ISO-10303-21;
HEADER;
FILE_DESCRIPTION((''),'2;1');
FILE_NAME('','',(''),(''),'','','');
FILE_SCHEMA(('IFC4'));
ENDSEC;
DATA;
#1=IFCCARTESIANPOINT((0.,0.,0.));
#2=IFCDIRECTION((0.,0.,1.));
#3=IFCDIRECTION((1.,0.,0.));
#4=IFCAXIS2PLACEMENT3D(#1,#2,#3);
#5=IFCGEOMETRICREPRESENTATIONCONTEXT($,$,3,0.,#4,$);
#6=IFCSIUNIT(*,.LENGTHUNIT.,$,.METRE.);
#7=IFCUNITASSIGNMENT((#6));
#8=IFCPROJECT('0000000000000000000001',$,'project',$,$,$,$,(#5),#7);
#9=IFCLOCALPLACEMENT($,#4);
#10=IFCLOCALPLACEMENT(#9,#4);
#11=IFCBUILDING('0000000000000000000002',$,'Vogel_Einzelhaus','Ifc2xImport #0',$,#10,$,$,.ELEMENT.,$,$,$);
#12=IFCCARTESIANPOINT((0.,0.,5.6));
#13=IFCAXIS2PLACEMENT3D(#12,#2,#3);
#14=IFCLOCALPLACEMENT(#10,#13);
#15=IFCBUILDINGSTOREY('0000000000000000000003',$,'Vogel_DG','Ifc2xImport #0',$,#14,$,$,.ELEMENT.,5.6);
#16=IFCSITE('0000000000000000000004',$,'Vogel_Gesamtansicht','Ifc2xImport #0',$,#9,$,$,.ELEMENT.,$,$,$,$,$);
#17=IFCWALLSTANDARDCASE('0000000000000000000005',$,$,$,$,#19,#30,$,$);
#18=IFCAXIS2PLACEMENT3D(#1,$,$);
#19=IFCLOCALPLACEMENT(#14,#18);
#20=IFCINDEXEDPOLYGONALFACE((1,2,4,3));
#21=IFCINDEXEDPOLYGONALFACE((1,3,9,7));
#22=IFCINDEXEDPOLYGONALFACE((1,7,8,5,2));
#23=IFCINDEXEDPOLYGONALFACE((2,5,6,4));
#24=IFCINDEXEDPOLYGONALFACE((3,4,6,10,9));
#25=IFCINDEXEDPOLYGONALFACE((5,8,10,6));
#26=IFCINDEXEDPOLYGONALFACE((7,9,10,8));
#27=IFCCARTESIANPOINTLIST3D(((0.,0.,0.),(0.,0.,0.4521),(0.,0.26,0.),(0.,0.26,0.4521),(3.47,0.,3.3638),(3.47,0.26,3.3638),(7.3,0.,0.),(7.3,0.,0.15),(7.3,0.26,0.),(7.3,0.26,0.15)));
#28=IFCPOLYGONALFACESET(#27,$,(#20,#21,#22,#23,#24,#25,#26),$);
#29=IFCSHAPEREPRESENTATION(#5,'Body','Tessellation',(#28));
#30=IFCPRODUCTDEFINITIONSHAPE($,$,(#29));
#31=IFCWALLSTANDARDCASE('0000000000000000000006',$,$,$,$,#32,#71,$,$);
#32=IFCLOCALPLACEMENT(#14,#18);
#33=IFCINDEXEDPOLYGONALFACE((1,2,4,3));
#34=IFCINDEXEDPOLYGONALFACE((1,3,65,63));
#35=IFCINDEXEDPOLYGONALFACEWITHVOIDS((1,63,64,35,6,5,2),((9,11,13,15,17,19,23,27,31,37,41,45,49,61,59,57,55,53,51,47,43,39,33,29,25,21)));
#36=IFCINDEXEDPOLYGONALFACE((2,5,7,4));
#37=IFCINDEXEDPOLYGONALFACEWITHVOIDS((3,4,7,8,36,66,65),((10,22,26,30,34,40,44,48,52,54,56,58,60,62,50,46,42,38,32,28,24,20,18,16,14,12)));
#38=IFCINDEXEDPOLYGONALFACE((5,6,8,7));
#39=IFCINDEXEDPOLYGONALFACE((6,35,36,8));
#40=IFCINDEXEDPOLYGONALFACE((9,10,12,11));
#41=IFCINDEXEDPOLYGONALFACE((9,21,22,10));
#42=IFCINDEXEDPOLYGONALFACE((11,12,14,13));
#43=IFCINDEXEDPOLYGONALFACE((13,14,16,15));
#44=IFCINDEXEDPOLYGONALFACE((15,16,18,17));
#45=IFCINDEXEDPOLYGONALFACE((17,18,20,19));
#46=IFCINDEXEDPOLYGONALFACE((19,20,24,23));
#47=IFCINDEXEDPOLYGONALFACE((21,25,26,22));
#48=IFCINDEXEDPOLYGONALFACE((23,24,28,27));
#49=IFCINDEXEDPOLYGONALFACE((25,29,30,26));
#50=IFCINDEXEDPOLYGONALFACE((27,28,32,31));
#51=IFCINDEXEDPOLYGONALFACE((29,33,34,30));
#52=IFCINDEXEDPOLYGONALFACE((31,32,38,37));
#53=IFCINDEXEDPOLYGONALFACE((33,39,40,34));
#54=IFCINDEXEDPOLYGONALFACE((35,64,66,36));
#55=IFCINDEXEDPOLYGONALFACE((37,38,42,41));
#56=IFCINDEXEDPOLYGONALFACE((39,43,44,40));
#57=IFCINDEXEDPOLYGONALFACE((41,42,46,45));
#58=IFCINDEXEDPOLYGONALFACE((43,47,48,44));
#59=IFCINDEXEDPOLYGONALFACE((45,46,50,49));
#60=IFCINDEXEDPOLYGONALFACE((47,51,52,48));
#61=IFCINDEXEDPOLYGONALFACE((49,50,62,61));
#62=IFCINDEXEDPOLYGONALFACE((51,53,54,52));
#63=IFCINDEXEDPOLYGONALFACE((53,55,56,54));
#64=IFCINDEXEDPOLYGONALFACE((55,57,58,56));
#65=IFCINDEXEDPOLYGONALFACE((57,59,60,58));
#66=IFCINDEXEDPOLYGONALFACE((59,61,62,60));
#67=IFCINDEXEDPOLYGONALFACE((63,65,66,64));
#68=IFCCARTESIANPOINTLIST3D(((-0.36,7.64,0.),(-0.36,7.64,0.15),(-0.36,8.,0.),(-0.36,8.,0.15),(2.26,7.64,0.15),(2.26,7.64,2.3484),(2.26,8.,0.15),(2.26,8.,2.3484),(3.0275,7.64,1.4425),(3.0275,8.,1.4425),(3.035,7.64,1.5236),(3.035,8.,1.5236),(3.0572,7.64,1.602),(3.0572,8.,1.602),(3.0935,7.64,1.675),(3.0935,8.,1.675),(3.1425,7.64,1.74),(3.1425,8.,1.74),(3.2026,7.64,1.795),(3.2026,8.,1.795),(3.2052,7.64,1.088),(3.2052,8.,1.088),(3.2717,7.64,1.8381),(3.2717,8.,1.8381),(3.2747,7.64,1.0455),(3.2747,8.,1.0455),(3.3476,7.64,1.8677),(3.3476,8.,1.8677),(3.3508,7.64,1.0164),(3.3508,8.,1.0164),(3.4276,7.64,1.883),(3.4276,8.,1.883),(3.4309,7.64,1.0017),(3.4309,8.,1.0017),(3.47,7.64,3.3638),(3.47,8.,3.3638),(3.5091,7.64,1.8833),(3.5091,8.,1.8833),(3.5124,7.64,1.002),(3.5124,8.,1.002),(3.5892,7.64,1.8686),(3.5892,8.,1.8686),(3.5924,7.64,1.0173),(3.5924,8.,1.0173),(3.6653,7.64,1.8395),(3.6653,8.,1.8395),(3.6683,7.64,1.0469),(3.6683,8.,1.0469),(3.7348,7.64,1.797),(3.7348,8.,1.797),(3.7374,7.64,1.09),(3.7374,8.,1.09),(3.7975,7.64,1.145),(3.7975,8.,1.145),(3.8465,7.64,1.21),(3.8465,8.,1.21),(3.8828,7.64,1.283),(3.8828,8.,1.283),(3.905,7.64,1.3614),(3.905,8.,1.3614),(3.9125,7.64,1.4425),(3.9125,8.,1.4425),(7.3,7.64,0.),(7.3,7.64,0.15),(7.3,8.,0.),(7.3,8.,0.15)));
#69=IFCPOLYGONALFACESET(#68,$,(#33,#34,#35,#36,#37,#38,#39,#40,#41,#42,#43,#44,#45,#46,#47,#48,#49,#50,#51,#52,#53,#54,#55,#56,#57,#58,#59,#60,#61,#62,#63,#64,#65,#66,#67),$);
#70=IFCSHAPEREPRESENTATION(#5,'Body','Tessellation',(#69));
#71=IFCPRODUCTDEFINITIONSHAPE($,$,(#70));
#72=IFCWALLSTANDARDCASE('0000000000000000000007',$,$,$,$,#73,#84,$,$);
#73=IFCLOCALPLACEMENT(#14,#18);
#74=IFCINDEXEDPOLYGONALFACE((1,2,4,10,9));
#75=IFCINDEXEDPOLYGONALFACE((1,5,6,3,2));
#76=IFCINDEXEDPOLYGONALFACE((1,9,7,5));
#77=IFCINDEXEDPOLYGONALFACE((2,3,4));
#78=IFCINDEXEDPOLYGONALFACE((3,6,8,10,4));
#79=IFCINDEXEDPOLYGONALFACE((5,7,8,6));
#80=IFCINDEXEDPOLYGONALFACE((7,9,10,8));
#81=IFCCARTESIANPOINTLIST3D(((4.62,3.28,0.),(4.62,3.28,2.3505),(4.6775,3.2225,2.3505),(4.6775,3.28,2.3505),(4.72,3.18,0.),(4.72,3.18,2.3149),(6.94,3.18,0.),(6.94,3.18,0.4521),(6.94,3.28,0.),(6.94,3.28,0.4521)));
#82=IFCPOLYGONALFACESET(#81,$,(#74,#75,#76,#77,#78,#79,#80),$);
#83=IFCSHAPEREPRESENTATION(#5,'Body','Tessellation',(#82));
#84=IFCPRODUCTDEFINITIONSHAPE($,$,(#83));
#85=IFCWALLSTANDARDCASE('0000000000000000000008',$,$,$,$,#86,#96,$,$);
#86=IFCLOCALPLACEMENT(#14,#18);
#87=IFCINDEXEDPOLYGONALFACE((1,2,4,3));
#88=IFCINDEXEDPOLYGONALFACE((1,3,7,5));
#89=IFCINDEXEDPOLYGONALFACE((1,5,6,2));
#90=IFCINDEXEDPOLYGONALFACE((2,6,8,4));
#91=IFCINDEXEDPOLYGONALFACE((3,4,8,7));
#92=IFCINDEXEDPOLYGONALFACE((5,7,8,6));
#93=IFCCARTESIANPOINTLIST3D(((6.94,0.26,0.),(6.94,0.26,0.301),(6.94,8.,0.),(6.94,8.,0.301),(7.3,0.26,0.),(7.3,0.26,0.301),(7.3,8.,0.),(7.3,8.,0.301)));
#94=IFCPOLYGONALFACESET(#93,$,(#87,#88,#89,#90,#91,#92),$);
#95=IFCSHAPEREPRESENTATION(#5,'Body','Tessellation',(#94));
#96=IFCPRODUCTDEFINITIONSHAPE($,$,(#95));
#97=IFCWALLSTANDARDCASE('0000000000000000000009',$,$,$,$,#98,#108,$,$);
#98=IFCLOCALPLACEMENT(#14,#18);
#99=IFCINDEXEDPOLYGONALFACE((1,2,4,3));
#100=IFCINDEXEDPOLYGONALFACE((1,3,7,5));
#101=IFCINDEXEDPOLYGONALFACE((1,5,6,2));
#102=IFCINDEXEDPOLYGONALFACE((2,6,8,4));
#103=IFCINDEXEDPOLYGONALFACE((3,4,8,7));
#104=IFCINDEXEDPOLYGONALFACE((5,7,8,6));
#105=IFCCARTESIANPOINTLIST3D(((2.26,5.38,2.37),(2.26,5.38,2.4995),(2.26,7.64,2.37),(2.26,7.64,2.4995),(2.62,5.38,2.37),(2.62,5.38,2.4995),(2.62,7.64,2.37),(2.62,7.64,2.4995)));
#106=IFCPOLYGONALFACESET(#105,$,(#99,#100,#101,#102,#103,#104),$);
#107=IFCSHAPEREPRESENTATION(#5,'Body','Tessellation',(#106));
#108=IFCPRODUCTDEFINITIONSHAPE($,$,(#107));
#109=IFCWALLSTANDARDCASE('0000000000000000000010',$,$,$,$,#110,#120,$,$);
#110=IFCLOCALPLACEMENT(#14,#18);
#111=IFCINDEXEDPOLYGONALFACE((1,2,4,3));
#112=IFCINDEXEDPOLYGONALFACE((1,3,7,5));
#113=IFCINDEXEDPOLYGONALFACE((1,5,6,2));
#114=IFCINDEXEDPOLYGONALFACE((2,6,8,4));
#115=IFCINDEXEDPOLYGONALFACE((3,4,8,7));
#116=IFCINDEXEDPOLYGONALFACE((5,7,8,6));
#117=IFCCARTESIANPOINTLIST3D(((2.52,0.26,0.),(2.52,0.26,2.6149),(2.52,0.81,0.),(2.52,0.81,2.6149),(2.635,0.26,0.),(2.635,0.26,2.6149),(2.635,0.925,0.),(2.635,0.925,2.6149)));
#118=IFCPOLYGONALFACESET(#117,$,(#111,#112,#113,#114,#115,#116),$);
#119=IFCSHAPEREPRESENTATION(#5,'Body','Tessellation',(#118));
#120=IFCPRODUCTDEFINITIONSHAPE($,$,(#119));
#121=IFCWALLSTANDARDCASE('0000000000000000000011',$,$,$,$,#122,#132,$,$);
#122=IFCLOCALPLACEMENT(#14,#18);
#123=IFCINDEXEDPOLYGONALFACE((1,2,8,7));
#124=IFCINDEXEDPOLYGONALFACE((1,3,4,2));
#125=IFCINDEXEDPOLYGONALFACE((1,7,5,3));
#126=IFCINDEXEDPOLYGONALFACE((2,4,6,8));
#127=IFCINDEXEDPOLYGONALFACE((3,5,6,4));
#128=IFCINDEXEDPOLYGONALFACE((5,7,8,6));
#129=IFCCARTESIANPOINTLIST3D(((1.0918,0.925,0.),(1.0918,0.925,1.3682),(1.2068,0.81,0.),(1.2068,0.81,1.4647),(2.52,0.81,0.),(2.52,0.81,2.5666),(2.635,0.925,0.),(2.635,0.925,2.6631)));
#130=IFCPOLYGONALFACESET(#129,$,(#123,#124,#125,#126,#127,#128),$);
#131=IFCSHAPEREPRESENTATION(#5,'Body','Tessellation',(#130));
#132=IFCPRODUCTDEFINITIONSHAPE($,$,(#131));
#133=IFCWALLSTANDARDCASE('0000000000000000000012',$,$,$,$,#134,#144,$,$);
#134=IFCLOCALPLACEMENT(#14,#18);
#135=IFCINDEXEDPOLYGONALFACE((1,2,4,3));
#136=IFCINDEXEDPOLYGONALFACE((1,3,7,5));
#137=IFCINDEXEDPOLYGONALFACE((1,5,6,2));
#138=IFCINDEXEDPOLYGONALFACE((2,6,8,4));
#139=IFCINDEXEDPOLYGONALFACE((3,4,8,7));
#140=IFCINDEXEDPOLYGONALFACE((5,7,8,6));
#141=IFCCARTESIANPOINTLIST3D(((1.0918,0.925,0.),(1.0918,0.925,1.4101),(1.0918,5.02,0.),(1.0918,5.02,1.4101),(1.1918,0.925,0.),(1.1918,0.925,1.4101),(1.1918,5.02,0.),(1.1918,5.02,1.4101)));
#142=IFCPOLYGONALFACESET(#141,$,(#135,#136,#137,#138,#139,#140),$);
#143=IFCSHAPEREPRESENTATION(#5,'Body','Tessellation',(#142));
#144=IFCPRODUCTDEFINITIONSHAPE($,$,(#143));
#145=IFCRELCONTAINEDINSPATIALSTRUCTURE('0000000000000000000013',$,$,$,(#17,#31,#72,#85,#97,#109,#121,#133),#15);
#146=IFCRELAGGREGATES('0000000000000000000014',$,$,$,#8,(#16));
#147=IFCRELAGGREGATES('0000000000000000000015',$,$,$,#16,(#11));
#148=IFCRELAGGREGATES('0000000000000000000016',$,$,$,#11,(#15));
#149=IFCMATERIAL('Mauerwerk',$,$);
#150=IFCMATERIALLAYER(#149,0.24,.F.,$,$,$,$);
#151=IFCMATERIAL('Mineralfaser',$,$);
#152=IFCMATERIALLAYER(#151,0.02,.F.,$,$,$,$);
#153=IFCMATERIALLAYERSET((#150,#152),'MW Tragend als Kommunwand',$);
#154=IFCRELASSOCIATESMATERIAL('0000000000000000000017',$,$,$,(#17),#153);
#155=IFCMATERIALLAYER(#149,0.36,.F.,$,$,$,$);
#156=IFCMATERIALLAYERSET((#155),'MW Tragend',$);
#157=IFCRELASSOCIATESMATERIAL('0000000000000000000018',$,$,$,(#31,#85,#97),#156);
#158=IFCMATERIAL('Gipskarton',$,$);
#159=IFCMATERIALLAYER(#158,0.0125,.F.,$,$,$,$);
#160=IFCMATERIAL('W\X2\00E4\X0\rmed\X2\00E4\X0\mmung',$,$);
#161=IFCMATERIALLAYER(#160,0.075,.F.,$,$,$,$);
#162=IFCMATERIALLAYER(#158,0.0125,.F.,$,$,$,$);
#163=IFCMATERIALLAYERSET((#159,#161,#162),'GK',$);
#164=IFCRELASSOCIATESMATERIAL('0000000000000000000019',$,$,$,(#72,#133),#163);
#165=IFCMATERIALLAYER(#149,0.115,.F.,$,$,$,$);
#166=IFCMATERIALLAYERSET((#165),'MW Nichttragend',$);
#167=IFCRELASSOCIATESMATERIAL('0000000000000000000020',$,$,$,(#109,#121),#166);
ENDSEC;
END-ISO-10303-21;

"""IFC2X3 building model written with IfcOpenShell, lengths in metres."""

from ifc_helpers import new_model, si_unit, point, frame, frame_2d, origin_with_axes, origin_2d_with_axis, place, context, project, spatial, polyline, circle_curve, parameter, trimmed, segment, composite_curve, rectangle, outline, extrude, clip, bounded_halfspace, shape, material, layer, layer_set, layer_usage, element, save


model = new_model("IFC2X3")

# Units and contexts
context_of_model = context(None, 3, precision=0.0, world=origin_with_axes())
ifc_project = project(units=[si_unit("LENGTHUNIT", "METRE")], contexts=[context_of_model])

# Site, building, storey
site_placement = place(None, origin_with_axes())
site = spatial("IfcSite", under=ifc_project, at=site_placement, Name="Vogel_Gesamtansicht", Description="Ifc2xImport #0", CompositionType="ELEMENT")
building_placement = place(site_placement, origin_with_axes())
building = spatial("IfcBuilding", under=site, at=building_placement, Name="Vogel_Einzelhaus", Description="Ifc2xImport #0", CompositionType="ELEMENT")
storey_placement = place(building_placement, frame((0.0, 0.0, 5.6), z_axis=(0.0, 0.0, 1.0), x_axis=(1.0, 0.0, 0.0)))
storey = spatial("IfcBuildingStorey", under=building, at=storey_placement, Name="Vogel_DG", Description="Ifc2xImport #0", CompositionType="ELEMENT", Elevation=5.6)

# Wall
ifc_material_1 = material(Name="Mauerwerk")
ifc_layer_1 = layer(ifc_material_1, 0.24, ventilated=False)
ifc_material_2 = material(Name="Mineralfaser")
ifc_layer_2 = layer(ifc_material_2, 0.02, ventilated=False)
ifc_layer_set_1 = layer_set([ifc_layer_1, ifc_layer_2], Name="MW Tragend als Kommunwand")
ifc_layer_usage_1 = layer_usage(ifc_layer_set_1, "AXIS2", "POSITIVE", -0.26)
wall_1_placement = place(storey_placement, frame((7.3, 0.0, 0.0), z_axis=(0.0, 0.0, 1.0), x_axis=(-1.0, 0.0, 0.0)))
element("IfcWallStandardCase", 1, at=wall_1_placement, inside=storey, material=ifc_layer_usage_1, context=context_of_model, shape_type="Clipping", body=[
    clip(clip(extrude(outline(polyline([(0.0, -0.26), (2.58, -0.26), (2.68, -0.26), (4.665, -0.26), (4.78, -0.26), (6.0932, -0.26), (6.2082, -0.26), (7.3, -0.26), (7.3, 0.0), (0.0, 0.0), (0.0, -0.26)])), origin_with_axes(), (0.0, 0.0, 1.0), 3.3638), bounded_halfspace(frame((0.0, 0.0, 0.15), z_axis=(0.642788, 0.0, -0.766044), x_axis=(0.766044, 0.0, 0.642788)), True, origin_with_axes(), polyline([(-7.3, -0.26), (3.83, -0.26), (3.83, 0.26), (-7.3, 0.26), (-7.3, -0.26)]))), bounded_halfspace(frame((3.83, 0.0, 3.3638), z_axis=(-0.642788, 0.0, -0.766044), x_axis=(0.766044, 0.0, -0.642788)), True, origin_with_axes(), polyline([(3.83, -0.26), (14.6, -0.26), (14.6, 0.26), (3.83, 0.26), (3.83, -0.26)]))),
])

# Wall, opening
ifc_layer_3 = layer(ifc_material_1, 0.36, ventilated=False)
ifc_layer_set_2 = layer_set([ifc_layer_3], Name="MW Tragend")
ifc_layer_usage_2 = layer_usage(ifc_layer_set_2, "AXIS2", "POSITIVE", -0.36)
wall_2_placement = place(storey_placement, frame((-0.36, 8.0, 0.0), z_axis=(0.0, 0.0, 1.0), x_axis=(1.0, 0.0, 0.0)))
wall_2 = element("IfcWallStandardCase", 2, at=wall_2_placement, inside=storey, material=ifc_layer_usage_2, context=context_of_model, shape_type="Clipping", body=[
    clip(clip(clip(extrude(outline(polyline([(0.0, 0.0), (0.0, -0.36), (7.66, -0.36), (7.66, 0.0), (0.0, 0.0)])), origin_with_axes(), (0.0, 0.0, 1.0), 3.3638), bounded_halfspace(frame((0.0, 0.0, 0.15), z_axis=(0.0, 0.0, -1.0), x_axis=(1.0, 0.0, 0.0)), True, origin_with_axes(), polyline([(-7.66, -0.36), (2.62, -0.36), (2.62, 0.36), (-7.66, 0.36), (-7.66, -0.36)]))), bounded_halfspace(frame((2.62, 0.0, 2.3484), z_axis=(0.642788, 0.0, -0.766044), x_axis=(0.766044, 0.0, 0.642788)), True, origin_with_axes(), polyline([(2.62, -0.36), (3.83, -0.36), (3.83, 0.36), (2.62, 0.36), (2.62, -0.36)]))), bounded_halfspace(frame((3.83, 0.0, 3.3638), z_axis=(-0.642788, 0.0, -0.766044), x_axis=(0.766044, 0.0, -0.642788)), True, origin_with_axes(), polyline([(3.83, -0.36), (15.32, -0.36), (15.32, 0.36), (3.83, 0.36), (3.83, -0.36)]))),
])
opening_1_placement = place(wall_2_placement, frame((4.2725, -0.36, 1.0), z_axis=(-1.0, 0.0, 0.0), x_axis=(0.0, 0.0, 1.0)))
element("IfcOpeningElement", 3, at=opening_1_placement, cuts=wall_2, shapes=[
    shape(context_of_model, None, "SweptSolid", [extrude(outline(composite_curve([segment(trimmed(circle_curve(frame_2d((0.4425, 0.4425), x_axis=(1.0, 0.0)), 0.4425), [parameter(0.0), point((0.885, 0.4425))], [parameter(180.0), point((0.0, 0.4425))], True, "PARAMETER"), True, "CONTINUOUS"), segment(trimmed(circle_curve(frame_2d((0.4425, 0.4425), x_axis=(-1.0, 0.0)), 0.4425), [parameter(0.0), point((0.0, 0.4425))], [parameter(180.0), point((0.885, 0.4425))], True, "PARAMETER"), True, "CONTINUOUS")], self_intersect="UNKNOWN")), frame((0.0, 0.0, 0.0), z_axis=(0.0, 1.0, 0.0), x_axis=(0.0, 0.0, 1.0)), (0.0, 0.0, 1.0), 0.36)]),
])

# Walls
ifc_material_3 = material(Name="Gipskarton")
ifc_layer_4 = layer(ifc_material_3, 0.0125, ventilated=False)
ifc_material_4 = material(Name="Wärmedämmung")
ifc_layer_5 = layer(ifc_material_4, 0.075, ventilated=False)
ifc_layer_6 = layer(ifc_material_3, 0.0125, ventilated=False)
ifc_layer_set_3 = layer_set([ifc_layer_4, ifc_layer_5, ifc_layer_6], Name="GK")
ifc_layer_usage_3 = layer_usage(ifc_layer_set_3, "AXIS2", "POSITIVE", -0.1)
wall_3_placement = place(storey_placement, frame((4.6775, 3.28, 0.0), z_axis=(0.0, 0.0, 1.0), x_axis=(1.0, 0.0, 0.0)))
element("IfcWallStandardCase", 4, at=wall_3_placement, inside=storey, material=ifc_layer_usage_3, context=context_of_model, shape_type="Clipping", body=[
    clip(extrude(outline(polyline([(2.2625, -0.1), (2.2625, 0.0), (-0.0575, 0.0), (0.0425, -0.1), (2.2625, -0.1)])), origin_with_axes(), (0.0, 0.0, 1.0), 2.3505), bounded_halfspace(frame((0.0, 0.0, 2.3505), z_axis=(-0.642788, 0.0, -0.766044), x_axis=(0.766044, 0.0, -0.642788)), True, origin_with_axes(), polyline([(-2.2625, -0.1), (2.2625, -0.1), (2.2625, 0.1), (-2.2625, 0.1), (-2.2625, -0.1)]))),
])
wall_4_placement = place(storey_placement, frame((7.3, 8.0, 0.0), z_axis=(0.0, 0.0, 1.0), x_axis=(0.0, -1.0, 0.0)))
element("IfcWallStandardCase", 5, at=wall_4_placement, inside=storey, material=ifc_layer_usage_2, context=context_of_model, shape_type="Clipping", body=[
    clip(extrude(outline(polyline([(0.0, 0.0), (0.0, -0.36), (7.74, -0.36), (7.74, 0.0), (0.0, 0.0)])), origin_with_axes(), (0.0, 0.0, 1.0), 0.301), bounded_halfspace(frame((0.0, 0.0, 0.301), z_axis=(0.0, 0.0, -1.0), x_axis=(1.0, 0.0, 0.0)), True, origin_with_axes(), polyline([(-7.74, -0.36), (7.74, -0.36), (7.74, 0.36), (-7.74, 0.36), (-7.74, -0.36)]))),
])

# Wall, opening
ifc_layer_usage_4 = layer_usage(ifc_layer_set_2, "AXIS2", "POSITIVE", 0.0)
wall_5_placement = place(storey_placement, frame((2.26, 7.64, 0.0), z_axis=(0.0, 0.0, 1.0), x_axis=(0.0, -1.0, 0.0)))
wall_5 = element("IfcWallStandardCase", 6, at=wall_5_placement, inside=storey, material=ifc_layer_usage_4, context=context_of_model, shape_type="Clipping", body=[
    clip(extrude(outline(polyline([(0.0, 0.36), (0.0, 0.0), (2.26, 0.0), (2.26, 0.36), (0.0, 0.36)])), origin_with_axes(), (0.0, 0.0, 1.0), 2.4995), bounded_halfspace(frame((0.0, 0.0, 2.4995), z_axis=(0.0, 0.0, -1.0), x_axis=(1.0, 0.0, 0.0)), True, origin_with_axes(), polyline([(-2.26, -0.36), (2.26, -0.36), (2.26, 0.36), (-2.26, 0.36), (-2.26, -0.36)]))),
])
opening_2_placement = place(wall_5_placement, frame((0.0, 0.36, 0.0), z_axis=(1.0, 0.0, 0.0), x_axis=(0.0, 0.0, 1.0)))
element("IfcOpeningElement", 7, at=opening_2_placement, cuts=wall_5, shapes=[
    shape(context_of_model, None, "SweptSolid", [extrude(rectangle(XDim=2.37, YDim=2.26, at=origin_2d_with_axis()), frame((1.185, 0.0, 1.13), z_axis=(0.0, 1.0, 0.0), x_axis=(1.0, 0.0, 0.0)), (0.0, 0.0, 1.0), 0.36)]),
])

# Walls
ifc_layer_7 = layer(ifc_material_1, 0.115, ventilated=False)
ifc_layer_set_4 = layer_set([ifc_layer_7], Name="MW Nichttragend")
ifc_layer_usage_5 = layer_usage(ifc_layer_set_4, "AXIS2", "POSITIVE", -0.115)
wall_6_placement = place(storey_placement, frame((2.52, 0.26, 0.0), z_axis=(0.0, 0.0, 1.0), x_axis=(0.0, 1.0, 0.0)))
element("IfcWallStandardCase", 8, at=wall_6_placement, inside=storey, material=ifc_layer_usage_5, context=context_of_model, shape_type="Clipping", body=[
    clip(extrude(outline(polyline([(0.665, -0.115), (0.55, 0.0), (0.0, 0.0), (0.0, -0.115), (0.665, -0.115)])), origin_with_axes(), (0.0, 0.0, 1.0), 2.6149), bounded_halfspace(frame((0.0, 0.0, 2.6149), z_axis=(0.0, 0.0, -1.0), x_axis=(1.0, 0.0, 0.0)), True, origin_with_axes(), polyline([(-0.55, -0.115), (0.55, -0.115), (0.55, 0.115), (-0.55, 0.115), (-0.55, -0.115)]))),
])
wall_7_placement = place(storey_placement, frame((1.0918, 0.925, 0.0), z_axis=(0.0, 0.0, 1.0), x_axis=(1.0, 0.0, 0.0)))
element("IfcWallStandardCase", 9, at=wall_7_placement, inside=storey, material=ifc_layer_usage_5, context=context_of_model, shape_type="Clipping", body=[
    clip(extrude(outline(polyline([(0.115, -0.115), (1.4282, -0.115), (1.5432, 0.0), (0.1, 0.0), (0.0, 0.0), (0.115, -0.115)])), origin_with_axes(), (0.0, 0.0, 1.0), 2.6631), bounded_halfspace(frame((0.0, 0.0, 1.3682), z_axis=(0.642788, 0.0, -0.766044), x_axis=(0.766044, 0.0, 0.642788)), True, origin_with_axes(), polyline([(-1.5432, -0.115), (1.5432, -0.115), (1.5432, 0.115), (-1.5432, 0.115), (-1.5432, -0.115)]))),
])
wall_8_placement = place(storey_placement, frame((1.1918, 5.02, 0.0), z_axis=(0.0, 0.0, 1.0), x_axis=(0.0, -1.0, 0.0)))
element("IfcWallStandardCase", 10, at=wall_8_placement, inside=storey, material=ifc_layer_usage_3, context=context_of_model, shape_type="Clipping", body=[
    clip(extrude(outline(polyline([(0.0, -0.1), (4.095, -0.1), (4.095, 0.0), (0.0, 0.0), (0.0, -0.1)])), origin_with_axes(), (0.0, 0.0, 1.0), 1.4101), bounded_halfspace(frame((0.0, 0.0, 1.4101), z_axis=(0.0, 0.0, -1.0), x_axis=(1.0, 0.0, 0.0)), True, origin_with_axes(), polyline([(-4.115, -0.1), (4.115, -0.1), (4.115, 0.1), (-4.115, 0.1), (-4.115, -0.1)]))),
])

save(model, "model.ifc")
